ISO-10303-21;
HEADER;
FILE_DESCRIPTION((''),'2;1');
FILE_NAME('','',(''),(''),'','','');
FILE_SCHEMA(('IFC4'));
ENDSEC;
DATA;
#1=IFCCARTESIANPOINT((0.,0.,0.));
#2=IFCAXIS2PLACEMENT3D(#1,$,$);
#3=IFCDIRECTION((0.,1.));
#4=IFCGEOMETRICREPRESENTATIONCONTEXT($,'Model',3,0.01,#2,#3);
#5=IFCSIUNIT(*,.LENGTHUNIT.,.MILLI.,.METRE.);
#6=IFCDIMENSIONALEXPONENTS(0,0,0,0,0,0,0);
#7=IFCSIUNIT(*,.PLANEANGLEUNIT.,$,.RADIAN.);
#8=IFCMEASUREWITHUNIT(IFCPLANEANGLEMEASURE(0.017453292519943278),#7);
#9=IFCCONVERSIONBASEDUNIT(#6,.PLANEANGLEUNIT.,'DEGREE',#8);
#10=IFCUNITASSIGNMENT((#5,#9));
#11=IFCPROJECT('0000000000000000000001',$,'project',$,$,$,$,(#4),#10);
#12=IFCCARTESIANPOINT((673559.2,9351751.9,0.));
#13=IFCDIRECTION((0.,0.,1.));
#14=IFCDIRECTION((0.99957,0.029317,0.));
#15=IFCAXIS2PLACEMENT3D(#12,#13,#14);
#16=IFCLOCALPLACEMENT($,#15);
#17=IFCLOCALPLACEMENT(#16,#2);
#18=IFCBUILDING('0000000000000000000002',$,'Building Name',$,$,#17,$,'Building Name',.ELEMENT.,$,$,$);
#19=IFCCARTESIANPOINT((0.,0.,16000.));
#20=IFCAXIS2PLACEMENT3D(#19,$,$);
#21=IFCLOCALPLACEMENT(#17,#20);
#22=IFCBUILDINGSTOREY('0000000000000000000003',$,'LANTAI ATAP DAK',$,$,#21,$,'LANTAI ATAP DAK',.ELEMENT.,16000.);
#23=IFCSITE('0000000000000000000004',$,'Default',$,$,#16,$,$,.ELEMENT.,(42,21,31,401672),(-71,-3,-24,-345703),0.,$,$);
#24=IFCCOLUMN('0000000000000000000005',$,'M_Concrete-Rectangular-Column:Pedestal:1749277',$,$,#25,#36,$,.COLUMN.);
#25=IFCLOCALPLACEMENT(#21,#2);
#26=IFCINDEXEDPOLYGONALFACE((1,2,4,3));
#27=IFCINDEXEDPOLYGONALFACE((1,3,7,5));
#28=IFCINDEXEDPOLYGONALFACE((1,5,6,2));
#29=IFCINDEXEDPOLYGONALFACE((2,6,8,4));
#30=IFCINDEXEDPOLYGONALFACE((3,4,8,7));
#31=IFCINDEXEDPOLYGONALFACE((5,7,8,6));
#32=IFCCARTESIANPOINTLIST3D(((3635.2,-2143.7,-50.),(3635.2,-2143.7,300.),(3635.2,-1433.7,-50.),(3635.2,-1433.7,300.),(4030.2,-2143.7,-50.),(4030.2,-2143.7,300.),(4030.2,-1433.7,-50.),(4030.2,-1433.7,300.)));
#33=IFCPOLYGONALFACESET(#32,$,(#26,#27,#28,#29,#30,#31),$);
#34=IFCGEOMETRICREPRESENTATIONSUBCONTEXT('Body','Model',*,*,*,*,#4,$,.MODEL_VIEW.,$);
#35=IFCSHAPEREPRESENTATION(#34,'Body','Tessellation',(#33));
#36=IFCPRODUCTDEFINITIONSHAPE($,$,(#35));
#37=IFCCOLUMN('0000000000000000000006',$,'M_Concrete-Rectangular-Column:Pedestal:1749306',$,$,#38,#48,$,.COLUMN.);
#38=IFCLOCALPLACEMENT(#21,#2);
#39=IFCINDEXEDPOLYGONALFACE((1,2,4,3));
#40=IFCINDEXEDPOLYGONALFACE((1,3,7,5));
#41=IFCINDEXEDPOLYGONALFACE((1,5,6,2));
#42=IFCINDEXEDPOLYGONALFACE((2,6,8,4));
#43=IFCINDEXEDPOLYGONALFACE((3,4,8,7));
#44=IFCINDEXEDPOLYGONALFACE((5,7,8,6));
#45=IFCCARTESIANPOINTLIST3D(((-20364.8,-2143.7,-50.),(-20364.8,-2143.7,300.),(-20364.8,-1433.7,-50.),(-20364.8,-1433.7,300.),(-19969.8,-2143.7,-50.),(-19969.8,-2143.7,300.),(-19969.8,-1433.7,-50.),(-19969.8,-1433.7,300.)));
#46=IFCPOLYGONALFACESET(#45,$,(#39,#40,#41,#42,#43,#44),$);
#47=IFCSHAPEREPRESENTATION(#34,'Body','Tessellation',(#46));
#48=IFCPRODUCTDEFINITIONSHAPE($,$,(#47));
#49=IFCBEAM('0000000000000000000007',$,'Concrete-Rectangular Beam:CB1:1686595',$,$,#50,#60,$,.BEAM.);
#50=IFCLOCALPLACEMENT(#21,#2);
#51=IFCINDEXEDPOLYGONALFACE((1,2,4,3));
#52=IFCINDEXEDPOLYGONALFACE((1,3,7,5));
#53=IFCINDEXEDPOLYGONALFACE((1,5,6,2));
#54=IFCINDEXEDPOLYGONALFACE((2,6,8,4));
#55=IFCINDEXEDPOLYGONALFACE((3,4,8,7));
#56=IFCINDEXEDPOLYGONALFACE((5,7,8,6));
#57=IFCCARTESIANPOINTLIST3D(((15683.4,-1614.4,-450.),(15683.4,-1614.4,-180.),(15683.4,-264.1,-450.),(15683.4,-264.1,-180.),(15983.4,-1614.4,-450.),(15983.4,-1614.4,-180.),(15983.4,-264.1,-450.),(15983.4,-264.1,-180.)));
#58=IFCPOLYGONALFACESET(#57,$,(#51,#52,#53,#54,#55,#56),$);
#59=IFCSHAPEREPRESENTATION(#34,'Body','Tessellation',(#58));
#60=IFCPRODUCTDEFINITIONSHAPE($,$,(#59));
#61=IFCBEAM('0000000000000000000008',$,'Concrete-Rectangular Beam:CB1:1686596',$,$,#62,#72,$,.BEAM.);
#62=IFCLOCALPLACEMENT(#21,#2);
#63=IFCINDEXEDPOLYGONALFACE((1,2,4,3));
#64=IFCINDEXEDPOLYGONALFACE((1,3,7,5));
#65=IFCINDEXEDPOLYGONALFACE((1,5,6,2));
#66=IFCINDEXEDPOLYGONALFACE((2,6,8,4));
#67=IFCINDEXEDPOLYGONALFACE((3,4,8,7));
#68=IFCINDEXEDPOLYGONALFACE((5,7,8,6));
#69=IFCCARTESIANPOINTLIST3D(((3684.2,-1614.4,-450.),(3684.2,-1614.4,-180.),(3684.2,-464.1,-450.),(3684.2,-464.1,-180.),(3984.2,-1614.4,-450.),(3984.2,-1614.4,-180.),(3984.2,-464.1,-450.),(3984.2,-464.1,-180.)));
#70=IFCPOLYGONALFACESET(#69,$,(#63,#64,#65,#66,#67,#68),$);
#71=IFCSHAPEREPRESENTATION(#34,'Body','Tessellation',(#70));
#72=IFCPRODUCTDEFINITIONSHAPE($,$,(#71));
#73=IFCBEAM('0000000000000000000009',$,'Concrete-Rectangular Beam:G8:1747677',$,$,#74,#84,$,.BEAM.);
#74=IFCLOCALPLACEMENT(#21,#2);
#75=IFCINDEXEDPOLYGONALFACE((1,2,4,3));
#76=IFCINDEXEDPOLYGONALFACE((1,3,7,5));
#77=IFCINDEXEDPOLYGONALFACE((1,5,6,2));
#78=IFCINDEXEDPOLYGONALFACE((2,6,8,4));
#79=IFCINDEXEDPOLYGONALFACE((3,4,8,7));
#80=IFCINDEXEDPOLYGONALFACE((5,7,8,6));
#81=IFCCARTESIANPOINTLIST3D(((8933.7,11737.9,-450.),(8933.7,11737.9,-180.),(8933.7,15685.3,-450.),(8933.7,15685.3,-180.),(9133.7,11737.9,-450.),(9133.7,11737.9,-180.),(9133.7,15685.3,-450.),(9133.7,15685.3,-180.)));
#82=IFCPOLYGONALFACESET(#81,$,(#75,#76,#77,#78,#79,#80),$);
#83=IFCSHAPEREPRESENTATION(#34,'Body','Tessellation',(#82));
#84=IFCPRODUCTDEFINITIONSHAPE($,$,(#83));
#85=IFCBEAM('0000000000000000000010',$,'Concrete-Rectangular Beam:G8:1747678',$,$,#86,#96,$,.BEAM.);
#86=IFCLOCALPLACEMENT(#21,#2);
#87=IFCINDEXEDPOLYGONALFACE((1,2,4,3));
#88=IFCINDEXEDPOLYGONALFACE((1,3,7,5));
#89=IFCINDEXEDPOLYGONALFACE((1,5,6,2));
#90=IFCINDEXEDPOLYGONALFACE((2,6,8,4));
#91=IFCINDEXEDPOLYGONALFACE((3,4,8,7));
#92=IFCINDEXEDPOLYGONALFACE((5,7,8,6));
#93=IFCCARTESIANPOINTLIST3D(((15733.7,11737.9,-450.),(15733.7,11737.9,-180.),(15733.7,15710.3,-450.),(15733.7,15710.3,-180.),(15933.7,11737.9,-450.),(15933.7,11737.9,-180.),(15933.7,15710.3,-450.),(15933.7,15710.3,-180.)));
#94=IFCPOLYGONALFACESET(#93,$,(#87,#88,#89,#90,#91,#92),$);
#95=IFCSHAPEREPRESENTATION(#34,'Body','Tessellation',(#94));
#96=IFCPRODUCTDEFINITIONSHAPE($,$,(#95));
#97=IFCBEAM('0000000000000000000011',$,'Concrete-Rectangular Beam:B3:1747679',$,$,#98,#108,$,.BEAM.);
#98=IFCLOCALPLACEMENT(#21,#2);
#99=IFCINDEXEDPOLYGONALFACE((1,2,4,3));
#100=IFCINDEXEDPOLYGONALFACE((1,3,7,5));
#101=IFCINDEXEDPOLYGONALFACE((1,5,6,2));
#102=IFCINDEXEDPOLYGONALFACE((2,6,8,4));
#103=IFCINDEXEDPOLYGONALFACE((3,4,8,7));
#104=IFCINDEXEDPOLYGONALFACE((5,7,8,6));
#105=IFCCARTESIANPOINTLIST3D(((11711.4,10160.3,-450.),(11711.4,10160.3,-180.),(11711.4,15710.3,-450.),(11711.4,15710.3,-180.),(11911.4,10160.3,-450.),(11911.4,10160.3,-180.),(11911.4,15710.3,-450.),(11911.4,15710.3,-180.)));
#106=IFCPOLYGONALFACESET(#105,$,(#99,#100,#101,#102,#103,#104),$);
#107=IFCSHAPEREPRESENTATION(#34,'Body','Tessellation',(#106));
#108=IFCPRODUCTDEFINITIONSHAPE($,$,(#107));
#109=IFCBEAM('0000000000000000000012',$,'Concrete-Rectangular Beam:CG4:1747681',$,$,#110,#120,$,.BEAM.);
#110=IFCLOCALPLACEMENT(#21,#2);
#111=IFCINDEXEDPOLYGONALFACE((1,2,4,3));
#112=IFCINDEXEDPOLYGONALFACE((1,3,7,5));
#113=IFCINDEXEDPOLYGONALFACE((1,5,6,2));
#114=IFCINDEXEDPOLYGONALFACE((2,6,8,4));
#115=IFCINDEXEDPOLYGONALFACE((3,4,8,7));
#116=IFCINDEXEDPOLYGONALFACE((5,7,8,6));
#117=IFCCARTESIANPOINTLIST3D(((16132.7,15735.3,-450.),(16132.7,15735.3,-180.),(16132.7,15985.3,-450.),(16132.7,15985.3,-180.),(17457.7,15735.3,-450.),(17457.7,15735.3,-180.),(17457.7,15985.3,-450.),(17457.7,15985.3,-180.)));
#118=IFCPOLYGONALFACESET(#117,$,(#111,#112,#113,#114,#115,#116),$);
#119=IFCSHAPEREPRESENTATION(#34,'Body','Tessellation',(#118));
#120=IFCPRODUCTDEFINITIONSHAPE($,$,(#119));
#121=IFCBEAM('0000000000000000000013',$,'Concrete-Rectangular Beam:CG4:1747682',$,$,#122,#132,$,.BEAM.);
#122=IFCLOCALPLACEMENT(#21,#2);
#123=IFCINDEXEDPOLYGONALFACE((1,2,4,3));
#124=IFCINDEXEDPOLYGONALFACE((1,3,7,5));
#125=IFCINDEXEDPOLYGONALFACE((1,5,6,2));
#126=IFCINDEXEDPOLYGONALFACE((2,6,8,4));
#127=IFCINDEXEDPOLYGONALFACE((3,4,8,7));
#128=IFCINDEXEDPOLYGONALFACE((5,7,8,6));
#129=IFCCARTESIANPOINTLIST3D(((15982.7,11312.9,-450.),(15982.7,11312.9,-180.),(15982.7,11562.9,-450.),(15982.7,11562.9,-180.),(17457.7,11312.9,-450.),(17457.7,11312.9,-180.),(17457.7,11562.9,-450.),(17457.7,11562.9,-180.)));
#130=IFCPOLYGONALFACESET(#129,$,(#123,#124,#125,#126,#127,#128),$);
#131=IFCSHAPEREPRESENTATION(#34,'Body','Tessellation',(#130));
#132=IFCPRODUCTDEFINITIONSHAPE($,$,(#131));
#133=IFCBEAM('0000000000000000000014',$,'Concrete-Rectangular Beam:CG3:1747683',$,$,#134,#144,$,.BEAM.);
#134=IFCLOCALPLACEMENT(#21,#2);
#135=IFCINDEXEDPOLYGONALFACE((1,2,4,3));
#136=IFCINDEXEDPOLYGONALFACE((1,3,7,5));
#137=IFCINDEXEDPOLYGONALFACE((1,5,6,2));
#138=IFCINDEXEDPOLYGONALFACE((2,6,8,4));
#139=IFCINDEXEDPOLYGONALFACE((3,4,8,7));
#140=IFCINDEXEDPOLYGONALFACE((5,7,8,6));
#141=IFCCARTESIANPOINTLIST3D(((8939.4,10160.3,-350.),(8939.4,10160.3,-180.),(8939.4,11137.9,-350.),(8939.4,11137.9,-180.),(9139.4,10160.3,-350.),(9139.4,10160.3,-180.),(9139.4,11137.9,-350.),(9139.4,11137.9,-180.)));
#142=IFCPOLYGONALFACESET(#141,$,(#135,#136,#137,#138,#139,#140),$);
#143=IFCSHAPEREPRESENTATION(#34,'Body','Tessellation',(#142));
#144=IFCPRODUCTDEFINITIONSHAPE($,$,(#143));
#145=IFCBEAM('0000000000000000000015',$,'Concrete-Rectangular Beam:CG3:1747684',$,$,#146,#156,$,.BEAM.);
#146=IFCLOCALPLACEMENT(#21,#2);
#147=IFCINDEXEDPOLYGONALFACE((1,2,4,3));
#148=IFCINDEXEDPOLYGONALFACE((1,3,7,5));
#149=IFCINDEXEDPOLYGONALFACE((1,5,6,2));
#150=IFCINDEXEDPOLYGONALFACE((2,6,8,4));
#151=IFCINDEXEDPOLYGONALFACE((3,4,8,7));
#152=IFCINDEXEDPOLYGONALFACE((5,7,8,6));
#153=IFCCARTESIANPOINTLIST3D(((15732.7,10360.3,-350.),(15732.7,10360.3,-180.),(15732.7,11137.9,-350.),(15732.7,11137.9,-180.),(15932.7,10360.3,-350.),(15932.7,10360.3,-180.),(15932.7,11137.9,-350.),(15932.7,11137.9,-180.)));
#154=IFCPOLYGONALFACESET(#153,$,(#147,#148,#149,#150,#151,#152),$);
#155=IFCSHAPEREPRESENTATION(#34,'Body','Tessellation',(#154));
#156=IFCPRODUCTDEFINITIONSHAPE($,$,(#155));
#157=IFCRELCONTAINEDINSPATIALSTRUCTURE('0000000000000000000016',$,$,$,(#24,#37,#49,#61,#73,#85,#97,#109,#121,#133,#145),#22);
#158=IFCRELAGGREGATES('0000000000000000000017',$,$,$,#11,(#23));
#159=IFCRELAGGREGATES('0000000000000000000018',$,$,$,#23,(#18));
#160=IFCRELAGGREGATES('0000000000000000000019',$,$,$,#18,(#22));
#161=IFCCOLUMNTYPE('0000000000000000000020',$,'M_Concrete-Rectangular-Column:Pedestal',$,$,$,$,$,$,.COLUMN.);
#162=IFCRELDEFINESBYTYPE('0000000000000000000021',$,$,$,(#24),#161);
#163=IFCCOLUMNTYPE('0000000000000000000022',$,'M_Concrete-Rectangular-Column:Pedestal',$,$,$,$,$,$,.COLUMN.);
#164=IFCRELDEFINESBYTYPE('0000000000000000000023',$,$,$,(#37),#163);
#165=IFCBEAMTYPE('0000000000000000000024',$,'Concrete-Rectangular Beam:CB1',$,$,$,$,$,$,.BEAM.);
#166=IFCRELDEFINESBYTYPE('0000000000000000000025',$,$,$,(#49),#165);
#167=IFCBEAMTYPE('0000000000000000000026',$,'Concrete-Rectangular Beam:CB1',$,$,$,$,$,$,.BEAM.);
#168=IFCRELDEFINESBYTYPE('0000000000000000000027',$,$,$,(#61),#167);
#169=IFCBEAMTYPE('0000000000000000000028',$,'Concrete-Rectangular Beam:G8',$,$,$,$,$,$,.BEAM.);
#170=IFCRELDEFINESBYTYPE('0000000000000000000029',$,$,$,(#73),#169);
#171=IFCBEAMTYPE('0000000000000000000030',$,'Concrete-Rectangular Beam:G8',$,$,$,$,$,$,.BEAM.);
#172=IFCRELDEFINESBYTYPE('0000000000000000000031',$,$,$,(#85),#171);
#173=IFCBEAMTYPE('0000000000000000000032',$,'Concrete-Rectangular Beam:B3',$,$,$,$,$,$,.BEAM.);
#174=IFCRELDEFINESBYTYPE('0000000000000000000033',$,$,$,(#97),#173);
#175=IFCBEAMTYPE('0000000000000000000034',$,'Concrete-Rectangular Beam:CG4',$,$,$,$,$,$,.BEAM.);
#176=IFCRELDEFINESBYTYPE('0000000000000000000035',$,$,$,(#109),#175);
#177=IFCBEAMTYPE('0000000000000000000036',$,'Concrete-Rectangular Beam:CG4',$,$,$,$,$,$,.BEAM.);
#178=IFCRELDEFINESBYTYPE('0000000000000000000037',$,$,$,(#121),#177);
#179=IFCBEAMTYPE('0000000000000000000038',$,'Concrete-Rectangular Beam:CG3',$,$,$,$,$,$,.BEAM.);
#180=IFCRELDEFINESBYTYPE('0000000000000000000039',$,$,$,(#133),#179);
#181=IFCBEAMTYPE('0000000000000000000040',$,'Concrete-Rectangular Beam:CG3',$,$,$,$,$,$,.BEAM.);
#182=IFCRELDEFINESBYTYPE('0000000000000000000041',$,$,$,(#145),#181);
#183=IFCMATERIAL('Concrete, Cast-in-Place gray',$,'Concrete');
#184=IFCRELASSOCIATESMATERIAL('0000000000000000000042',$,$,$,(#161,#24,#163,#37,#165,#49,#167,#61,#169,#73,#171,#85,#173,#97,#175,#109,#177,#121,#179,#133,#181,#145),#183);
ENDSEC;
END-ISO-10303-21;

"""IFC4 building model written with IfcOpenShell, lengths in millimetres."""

from ifc_helpers import new_model, entity, si_unit, converted_unit, direction, frame, origin, place, context, subcontext, project, spatial, indexed_curve, outline, extrude, source, transform, mapped, material, type_object, type_shapes, element, save


model = new_model("IFC4")

# Units and contexts
model_context = context("Model", 3, precision=0.01, world=origin(), true_north=direction((0.0, 1.0)))
body_context = subcontext(model_context, "Body", "Model", "MODEL_VIEW")
ifc_project = project(units=[si_unit("LENGTHUNIT", "METRE", prefix="MILLI"), converted_unit("PLANEANGLEUNIT", "DEGREE", entity("IfcPlaneAngleMeasure", 0.017453292519943278), si_unit("PLANEANGLEUNIT", "RADIAN"), dimensions=[0, 0, 0, 0, 0, 0, 0])], contexts=[model_context])

# Site, building, storey
site_placement = place(None, frame((673559.2, 9351751.9, 0.0), z_axis=(0.0, 0.0, 1.0), x_axis=(0.99957, 0.029317, 0.0)))
site = spatial("IfcSite", under=ifc_project, at=site_placement, Name="Default", CompositionType="ELEMENT", RefLatitude=(42, 21, 31, 401672), RefLongitude=(-71, -3, -24, -345703), RefElevation=0.0)
building_placement = place(site_placement, origin())
building = spatial("IfcBuilding", under=site, at=building_placement, Name="Building Name", LongName="Building Name", CompositionType="ELEMENT")
storey_placement = place(building_placement, frame((0.0, 0.0, 16000.0)))
storey = spatial("IfcBuildingStorey", under=building, at=storey_placement, Name="LANTAI ATAP DAK", LongName="LANTAI ATAP DAK", CompositionType="ELEMENT", Elevation=16000.0)

# Columns
ifc_material = material(Name="Concrete, Cast-in-Place gray", Category="Concrete")
column_type_1 = type_object("IfcColumnType", Name="M_Concrete-Rectangular-Column:Pedestal", PredefinedType="COLUMN", material=ifc_material)
shared_shape_1 = source(origin(), body_context, "Body", "SweptSolid", [
    extrude(outline(indexed_curve([(-197.5, -355.0), (197.5, -355.0), (197.5, 355.0), (-197.5, 355.0), (-197.5, -355.0)], self_intersect=False)), frame((3832.7, -1788.7, 15950.0), z_axis=(0.0, 0.0, 1.0), x_axis=(-1.0, 0.0, 0.0)), (0.0, 0.0, 1.0), 350.0),
])
type_shapes(column_type_1, [shared_shape_1])
column_1_placement = place(storey_placement, frame((0.0, 0.0, -16000.0)))
element("IfcColumn", 1, at=column_1_placement, inside=storey, type_object=column_type_1, material=ifc_material, Name="M_Concrete-Rectangular-Column:Pedestal:1749277", PredefinedType="COLUMN", context=body_context, shape_type="MappedRepresentation", body=[
    mapped(shared_shape_1, transform((0.0, 0.0, 0.0), scale=1.0)),
])
column_type_2 = type_object("IfcColumnType", Name="M_Concrete-Rectangular-Column:Pedestal", PredefinedType="COLUMN", material=ifc_material)
shared_shape_2 = source(origin(), body_context, "Body", "SweptSolid", [
    extrude(outline(indexed_curve([(-197.5, -355.0), (197.5, -355.0), (197.5, 355.0), (-197.5, 355.0), (-197.5, -355.0)], self_intersect=False)), frame((-20167.3, -1788.7, 15950.0), z_axis=(0.0, 0.0, 1.0), x_axis=(-1.0, 0.0, 0.0)), (0.0, 0.0, 1.0), 350.0),
])
type_shapes(column_type_2, [shared_shape_2])
column_2_placement = place(storey_placement, frame((0.0, 0.0, -16000.0)))
element("IfcColumn", 2, at=column_2_placement, inside=storey, type_object=column_type_2, material=ifc_material, Name="M_Concrete-Rectangular-Column:Pedestal:1749306", PredefinedType="COLUMN", context=body_context, shape_type="MappedRepresentation", body=[
    mapped(shared_shape_2, transform((0.0, 0.0, 0.0), scale=1.0)),
])

# Beams
beam_type_1 = type_object("IfcBeamType", Name="Concrete-Rectangular Beam:CB1", PredefinedType="BEAM", material=ifc_material)
shared_shape_3 = source(origin(), body_context, "Body", "SweptSolid", [
    extrude(outline(indexed_curve([(-150.0, -135.0), (150.0, -135.0), (150.0, 135.0), (-150.0, 135.0), (-150.0, -135.0)], self_intersect=False)), frame((15833.4, -1614.4, 15685.0), z_axis=(0.0, 1.0, 0.0), x_axis=(-1.0, 0.0, 0.0)), (0.0, 0.0, 1.0), 1350.4),
])
type_shapes(beam_type_1, [shared_shape_3])
beam_1_placement = place(storey_placement, frame((0.0, 0.0, -16000.0)))
element("IfcBeam", 3, at=beam_1_placement, inside=storey, type_object=beam_type_1, material=ifc_material, Name="Concrete-Rectangular Beam:CB1:1686595", PredefinedType="BEAM", context=body_context, shape_type="MappedRepresentation", body=[
    mapped(shared_shape_3, transform((0.0, 0.0, 0.0), scale=1.0)),
])
beam_type_2 = type_object("IfcBeamType", Name="Concrete-Rectangular Beam:CB1", PredefinedType="BEAM", material=ifc_material)
shared_shape_4 = source(origin(), body_context, "Body", "SweptSolid", [
    extrude(outline(indexed_curve([(-150.0, -135.0), (150.0, -135.0), (150.0, 135.0), (-150.0, 135.0), (-150.0, -135.0)], self_intersect=False)), frame((3834.2, -1614.4, 15685.0), z_axis=(0.0, 1.0, 0.0), x_axis=(-1.0, 0.0, 0.0)), (0.0, 0.0, 1.0), 1150.4),
])
type_shapes(beam_type_2, [shared_shape_4])
beam_2_placement = place(storey_placement, frame((0.0, 0.0, -16000.0)))
element("IfcBeam", 4, at=beam_2_placement, inside=storey, type_object=beam_type_2, material=ifc_material, Name="Concrete-Rectangular Beam:CB1:1686596", PredefinedType="BEAM", context=body_context, shape_type="MappedRepresentation", body=[
    mapped(shared_shape_4, transform((0.0, 0.0, 0.0), scale=1.0)),
])
beam_type_3 = type_object("IfcBeamType", Name="Concrete-Rectangular Beam:G8", PredefinedType="BEAM", material=ifc_material)
shared_shape_5 = source(origin(), body_context, "Body", "SweptSolid", [
    extrude(outline(indexed_curve([(-100.0, -135.0), (100.0, -135.0), (100.0, 135.0), (-100.0, 135.0), (-100.0, -135.0)], self_intersect=False)), frame((9033.7, 15685.3, 15685.0), z_axis=(0.0, -1.0, 0.0), x_axis=(-1.0, 0.0, 0.0)), (0.0, 0.0, 1.0), 3947.4),
])
type_shapes(beam_type_3, [shared_shape_5])
beam_3_placement = place(storey_placement, frame((0.0, 0.0, -16000.0)))
element("IfcBeam", 5, at=beam_3_placement, inside=storey, type_object=beam_type_3, material=ifc_material, Name="Concrete-Rectangular Beam:G8:1747677", PredefinedType="BEAM", context=body_context, shape_type="MappedRepresentation", body=[
    mapped(shared_shape_5, transform((0.0, 0.0, 0.0), scale=1.0)),
])
beam_type_4 = type_object("IfcBeamType", Name="Concrete-Rectangular Beam:G8", PredefinedType="BEAM", material=ifc_material)
shared_shape_6 = source(origin(), body_context, "Body", "SweptSolid", [
    extrude(outline(indexed_curve([(-100.0, -135.0), (100.0, -135.0), (100.0, 135.0), (-100.0, 135.0), (-100.0, -135.0)], self_intersect=False)), frame((15833.7, 15710.3, 15685.0), z_axis=(0.0, -1.0, 0.0), x_axis=(-1.0, 0.0, 0.0)), (0.0, 0.0, 1.0), 3972.4),
])
type_shapes(beam_type_4, [shared_shape_6])
beam_4_placement = place(storey_placement, frame((0.0, 0.0, -16000.0)))
element("IfcBeam", 6, at=beam_4_placement, inside=storey, type_object=beam_type_4, material=ifc_material, Name="Concrete-Rectangular Beam:G8:1747678", PredefinedType="BEAM", context=body_context, shape_type="MappedRepresentation", body=[
    mapped(shared_shape_6, transform((0.0, 0.0, 0.0), scale=1.0)),
])
beam_type_5 = type_object("IfcBeamType", Name="Concrete-Rectangular Beam:B3", PredefinedType="BEAM", material=ifc_material)
shared_shape_7 = source(origin(), body_context, "Body", "SweptSolid", [
    extrude(outline(indexed_curve([(-100.0, -135.0), (100.0, -135.0), (100.0, 135.0), (-100.0, 135.0), (-100.0, -135.0)], self_intersect=False)), frame((11811.4, 15710.3, 15685.0), z_axis=(0.0, -1.0, 0.0), x_axis=(-1.0, 0.0, 0.0)), (0.0, 0.0, 1.0), 5550.0),
])
type_shapes(beam_type_5, [shared_shape_7])
beam_5_placement = place(storey_placement, frame((0.0, 0.0, -16000.0)))
element("IfcBeam", 7, at=beam_5_placement, inside=storey, type_object=beam_type_5, material=ifc_material, Name="Concrete-Rectangular Beam:B3:1747679", PredefinedType="BEAM", context=body_context, shape_type="MappedRepresentation", body=[
    mapped(shared_shape_7, transform((0.0, 0.0, 0.0), scale=1.0)),
])
beam_type_6 = type_object("IfcBeamType", Name="Concrete-Rectangular Beam:CG4", PredefinedType="BEAM", material=ifc_material)
shared_shape_8 = source(origin(), body_context, "Body", "SweptSolid", [
    extrude(outline(indexed_curve([(-135.0, -125.0), (135.0, -125.0), (135.0, 125.0), (-135.0, 125.0), (-135.0, -125.0)], self_intersect=False)), frame((17457.7, 15860.3, 15685.0), z_axis=(-1.0, 0.0, 0.0), x_axis=(0.0, 0.0, -1.0)), (0.0, 0.0, 1.0), 1325.0),
])
type_shapes(beam_type_6, [shared_shape_8])
beam_6_placement = place(storey_placement, frame((0.0, 0.0, -16000.0)))
element("IfcBeam", 8, at=beam_6_placement, inside=storey, type_object=beam_type_6, material=ifc_material, Name="Concrete-Rectangular Beam:CG4:1747681", PredefinedType="BEAM", context=body_context, shape_type="MappedRepresentation", body=[
    mapped(shared_shape_8, transform((0.0, 0.0, 0.0), scale=1.0)),
])
beam_type_7 = type_object("IfcBeamType", Name="Concrete-Rectangular Beam:CG4", PredefinedType="BEAM", material=ifc_material)
shared_shape_9 = source(origin(), body_context, "Body", "SweptSolid", [
    extrude(outline(indexed_curve([(-135.0, -125.0), (135.0, -125.0), (135.0, 125.0), (-135.0, 125.0), (-135.0, -125.0)], self_intersect=False)), frame((15982.7, 11437.9, 15685.0), z_axis=(1.0, 0.0, 0.0), x_axis=(0.0, 0.0, -1.0)), (0.0, 0.0, 1.0), 1475.0),
])
type_shapes(beam_type_7, [shared_shape_9])
beam_7_placement = place(storey_placement, frame((0.0, 0.0, -16000.0)))
element("IfcBeam", 9, at=beam_7_placement, inside=storey, type_object=beam_type_7, material=ifc_material, Name="Concrete-Rectangular Beam:CG4:1747682", PredefinedType="BEAM", context=body_context, shape_type="MappedRepresentation", body=[
    mapped(shared_shape_9, transform((0.0, 0.0, 0.0), scale=1.0)),
])
beam_type_8 = type_object("IfcBeamType", Name="Concrete-Rectangular Beam:CG3", PredefinedType="BEAM", material=ifc_material)
shared_shape_10 = source(origin(), body_context, "Body", "SweptSolid", [
    extrude(outline(indexed_curve([(-100.0, -85.0), (100.0, -85.0), (100.0, 85.0), (-100.0, 85.0), (-100.0, -85.0)], self_intersect=False)), frame((9039.4, 11137.9, 15735.0), z_axis=(0.0, -1.0, 0.0), x_axis=(-1.0, 0.0, 0.0)), (0.0, 0.0, 1.0), 977.6),
])
type_shapes(beam_type_8, [shared_shape_10])
beam_8_placement = place(storey_placement, frame((0.0, 0.0, -16000.0)))
element("IfcBeam", 10, at=beam_8_placement, inside=storey, type_object=beam_type_8, material=ifc_material, Name="Concrete-Rectangular Beam:CG3:1747683", PredefinedType="BEAM", context=body_context, shape_type="MappedRepresentation", body=[
    mapped(shared_shape_10, transform((0.0, 0.0, 0.0), scale=1.0)),
])
beam_type_9 = type_object("IfcBeamType", Name="Concrete-Rectangular Beam:CG3", PredefinedType="BEAM", material=ifc_material)
shared_shape_11 = source(origin(), body_context, "Body", "SweptSolid", [
    extrude(outline(indexed_curve([(-100.0, -85.0), (100.0, -85.0), (100.0, 85.0), (-100.0, 85.0), (-100.0, -85.0)], self_intersect=False)), frame((15832.7, 11137.9, 15735.0), z_axis=(0.0, -1.0, 0.0), x_axis=(-1.0, 0.0, 0.0)), (0.0, 0.0, 1.0), 777.6),
])
type_shapes(beam_type_9, [shared_shape_11])
beam_9_placement = place(storey_placement, frame((0.0, 0.0, -16000.0)))
element("IfcBeam", 11, at=beam_9_placement, inside=storey, type_object=beam_type_9, material=ifc_material, Name="Concrete-Rectangular Beam:CG3:1747684", PredefinedType="BEAM", context=body_context, shape_type="MappedRepresentation", body=[
    mapped(shared_shape_11, transform((0.0, 0.0, 0.0), scale=1.0)),
])

save(model, "model.ifc")
